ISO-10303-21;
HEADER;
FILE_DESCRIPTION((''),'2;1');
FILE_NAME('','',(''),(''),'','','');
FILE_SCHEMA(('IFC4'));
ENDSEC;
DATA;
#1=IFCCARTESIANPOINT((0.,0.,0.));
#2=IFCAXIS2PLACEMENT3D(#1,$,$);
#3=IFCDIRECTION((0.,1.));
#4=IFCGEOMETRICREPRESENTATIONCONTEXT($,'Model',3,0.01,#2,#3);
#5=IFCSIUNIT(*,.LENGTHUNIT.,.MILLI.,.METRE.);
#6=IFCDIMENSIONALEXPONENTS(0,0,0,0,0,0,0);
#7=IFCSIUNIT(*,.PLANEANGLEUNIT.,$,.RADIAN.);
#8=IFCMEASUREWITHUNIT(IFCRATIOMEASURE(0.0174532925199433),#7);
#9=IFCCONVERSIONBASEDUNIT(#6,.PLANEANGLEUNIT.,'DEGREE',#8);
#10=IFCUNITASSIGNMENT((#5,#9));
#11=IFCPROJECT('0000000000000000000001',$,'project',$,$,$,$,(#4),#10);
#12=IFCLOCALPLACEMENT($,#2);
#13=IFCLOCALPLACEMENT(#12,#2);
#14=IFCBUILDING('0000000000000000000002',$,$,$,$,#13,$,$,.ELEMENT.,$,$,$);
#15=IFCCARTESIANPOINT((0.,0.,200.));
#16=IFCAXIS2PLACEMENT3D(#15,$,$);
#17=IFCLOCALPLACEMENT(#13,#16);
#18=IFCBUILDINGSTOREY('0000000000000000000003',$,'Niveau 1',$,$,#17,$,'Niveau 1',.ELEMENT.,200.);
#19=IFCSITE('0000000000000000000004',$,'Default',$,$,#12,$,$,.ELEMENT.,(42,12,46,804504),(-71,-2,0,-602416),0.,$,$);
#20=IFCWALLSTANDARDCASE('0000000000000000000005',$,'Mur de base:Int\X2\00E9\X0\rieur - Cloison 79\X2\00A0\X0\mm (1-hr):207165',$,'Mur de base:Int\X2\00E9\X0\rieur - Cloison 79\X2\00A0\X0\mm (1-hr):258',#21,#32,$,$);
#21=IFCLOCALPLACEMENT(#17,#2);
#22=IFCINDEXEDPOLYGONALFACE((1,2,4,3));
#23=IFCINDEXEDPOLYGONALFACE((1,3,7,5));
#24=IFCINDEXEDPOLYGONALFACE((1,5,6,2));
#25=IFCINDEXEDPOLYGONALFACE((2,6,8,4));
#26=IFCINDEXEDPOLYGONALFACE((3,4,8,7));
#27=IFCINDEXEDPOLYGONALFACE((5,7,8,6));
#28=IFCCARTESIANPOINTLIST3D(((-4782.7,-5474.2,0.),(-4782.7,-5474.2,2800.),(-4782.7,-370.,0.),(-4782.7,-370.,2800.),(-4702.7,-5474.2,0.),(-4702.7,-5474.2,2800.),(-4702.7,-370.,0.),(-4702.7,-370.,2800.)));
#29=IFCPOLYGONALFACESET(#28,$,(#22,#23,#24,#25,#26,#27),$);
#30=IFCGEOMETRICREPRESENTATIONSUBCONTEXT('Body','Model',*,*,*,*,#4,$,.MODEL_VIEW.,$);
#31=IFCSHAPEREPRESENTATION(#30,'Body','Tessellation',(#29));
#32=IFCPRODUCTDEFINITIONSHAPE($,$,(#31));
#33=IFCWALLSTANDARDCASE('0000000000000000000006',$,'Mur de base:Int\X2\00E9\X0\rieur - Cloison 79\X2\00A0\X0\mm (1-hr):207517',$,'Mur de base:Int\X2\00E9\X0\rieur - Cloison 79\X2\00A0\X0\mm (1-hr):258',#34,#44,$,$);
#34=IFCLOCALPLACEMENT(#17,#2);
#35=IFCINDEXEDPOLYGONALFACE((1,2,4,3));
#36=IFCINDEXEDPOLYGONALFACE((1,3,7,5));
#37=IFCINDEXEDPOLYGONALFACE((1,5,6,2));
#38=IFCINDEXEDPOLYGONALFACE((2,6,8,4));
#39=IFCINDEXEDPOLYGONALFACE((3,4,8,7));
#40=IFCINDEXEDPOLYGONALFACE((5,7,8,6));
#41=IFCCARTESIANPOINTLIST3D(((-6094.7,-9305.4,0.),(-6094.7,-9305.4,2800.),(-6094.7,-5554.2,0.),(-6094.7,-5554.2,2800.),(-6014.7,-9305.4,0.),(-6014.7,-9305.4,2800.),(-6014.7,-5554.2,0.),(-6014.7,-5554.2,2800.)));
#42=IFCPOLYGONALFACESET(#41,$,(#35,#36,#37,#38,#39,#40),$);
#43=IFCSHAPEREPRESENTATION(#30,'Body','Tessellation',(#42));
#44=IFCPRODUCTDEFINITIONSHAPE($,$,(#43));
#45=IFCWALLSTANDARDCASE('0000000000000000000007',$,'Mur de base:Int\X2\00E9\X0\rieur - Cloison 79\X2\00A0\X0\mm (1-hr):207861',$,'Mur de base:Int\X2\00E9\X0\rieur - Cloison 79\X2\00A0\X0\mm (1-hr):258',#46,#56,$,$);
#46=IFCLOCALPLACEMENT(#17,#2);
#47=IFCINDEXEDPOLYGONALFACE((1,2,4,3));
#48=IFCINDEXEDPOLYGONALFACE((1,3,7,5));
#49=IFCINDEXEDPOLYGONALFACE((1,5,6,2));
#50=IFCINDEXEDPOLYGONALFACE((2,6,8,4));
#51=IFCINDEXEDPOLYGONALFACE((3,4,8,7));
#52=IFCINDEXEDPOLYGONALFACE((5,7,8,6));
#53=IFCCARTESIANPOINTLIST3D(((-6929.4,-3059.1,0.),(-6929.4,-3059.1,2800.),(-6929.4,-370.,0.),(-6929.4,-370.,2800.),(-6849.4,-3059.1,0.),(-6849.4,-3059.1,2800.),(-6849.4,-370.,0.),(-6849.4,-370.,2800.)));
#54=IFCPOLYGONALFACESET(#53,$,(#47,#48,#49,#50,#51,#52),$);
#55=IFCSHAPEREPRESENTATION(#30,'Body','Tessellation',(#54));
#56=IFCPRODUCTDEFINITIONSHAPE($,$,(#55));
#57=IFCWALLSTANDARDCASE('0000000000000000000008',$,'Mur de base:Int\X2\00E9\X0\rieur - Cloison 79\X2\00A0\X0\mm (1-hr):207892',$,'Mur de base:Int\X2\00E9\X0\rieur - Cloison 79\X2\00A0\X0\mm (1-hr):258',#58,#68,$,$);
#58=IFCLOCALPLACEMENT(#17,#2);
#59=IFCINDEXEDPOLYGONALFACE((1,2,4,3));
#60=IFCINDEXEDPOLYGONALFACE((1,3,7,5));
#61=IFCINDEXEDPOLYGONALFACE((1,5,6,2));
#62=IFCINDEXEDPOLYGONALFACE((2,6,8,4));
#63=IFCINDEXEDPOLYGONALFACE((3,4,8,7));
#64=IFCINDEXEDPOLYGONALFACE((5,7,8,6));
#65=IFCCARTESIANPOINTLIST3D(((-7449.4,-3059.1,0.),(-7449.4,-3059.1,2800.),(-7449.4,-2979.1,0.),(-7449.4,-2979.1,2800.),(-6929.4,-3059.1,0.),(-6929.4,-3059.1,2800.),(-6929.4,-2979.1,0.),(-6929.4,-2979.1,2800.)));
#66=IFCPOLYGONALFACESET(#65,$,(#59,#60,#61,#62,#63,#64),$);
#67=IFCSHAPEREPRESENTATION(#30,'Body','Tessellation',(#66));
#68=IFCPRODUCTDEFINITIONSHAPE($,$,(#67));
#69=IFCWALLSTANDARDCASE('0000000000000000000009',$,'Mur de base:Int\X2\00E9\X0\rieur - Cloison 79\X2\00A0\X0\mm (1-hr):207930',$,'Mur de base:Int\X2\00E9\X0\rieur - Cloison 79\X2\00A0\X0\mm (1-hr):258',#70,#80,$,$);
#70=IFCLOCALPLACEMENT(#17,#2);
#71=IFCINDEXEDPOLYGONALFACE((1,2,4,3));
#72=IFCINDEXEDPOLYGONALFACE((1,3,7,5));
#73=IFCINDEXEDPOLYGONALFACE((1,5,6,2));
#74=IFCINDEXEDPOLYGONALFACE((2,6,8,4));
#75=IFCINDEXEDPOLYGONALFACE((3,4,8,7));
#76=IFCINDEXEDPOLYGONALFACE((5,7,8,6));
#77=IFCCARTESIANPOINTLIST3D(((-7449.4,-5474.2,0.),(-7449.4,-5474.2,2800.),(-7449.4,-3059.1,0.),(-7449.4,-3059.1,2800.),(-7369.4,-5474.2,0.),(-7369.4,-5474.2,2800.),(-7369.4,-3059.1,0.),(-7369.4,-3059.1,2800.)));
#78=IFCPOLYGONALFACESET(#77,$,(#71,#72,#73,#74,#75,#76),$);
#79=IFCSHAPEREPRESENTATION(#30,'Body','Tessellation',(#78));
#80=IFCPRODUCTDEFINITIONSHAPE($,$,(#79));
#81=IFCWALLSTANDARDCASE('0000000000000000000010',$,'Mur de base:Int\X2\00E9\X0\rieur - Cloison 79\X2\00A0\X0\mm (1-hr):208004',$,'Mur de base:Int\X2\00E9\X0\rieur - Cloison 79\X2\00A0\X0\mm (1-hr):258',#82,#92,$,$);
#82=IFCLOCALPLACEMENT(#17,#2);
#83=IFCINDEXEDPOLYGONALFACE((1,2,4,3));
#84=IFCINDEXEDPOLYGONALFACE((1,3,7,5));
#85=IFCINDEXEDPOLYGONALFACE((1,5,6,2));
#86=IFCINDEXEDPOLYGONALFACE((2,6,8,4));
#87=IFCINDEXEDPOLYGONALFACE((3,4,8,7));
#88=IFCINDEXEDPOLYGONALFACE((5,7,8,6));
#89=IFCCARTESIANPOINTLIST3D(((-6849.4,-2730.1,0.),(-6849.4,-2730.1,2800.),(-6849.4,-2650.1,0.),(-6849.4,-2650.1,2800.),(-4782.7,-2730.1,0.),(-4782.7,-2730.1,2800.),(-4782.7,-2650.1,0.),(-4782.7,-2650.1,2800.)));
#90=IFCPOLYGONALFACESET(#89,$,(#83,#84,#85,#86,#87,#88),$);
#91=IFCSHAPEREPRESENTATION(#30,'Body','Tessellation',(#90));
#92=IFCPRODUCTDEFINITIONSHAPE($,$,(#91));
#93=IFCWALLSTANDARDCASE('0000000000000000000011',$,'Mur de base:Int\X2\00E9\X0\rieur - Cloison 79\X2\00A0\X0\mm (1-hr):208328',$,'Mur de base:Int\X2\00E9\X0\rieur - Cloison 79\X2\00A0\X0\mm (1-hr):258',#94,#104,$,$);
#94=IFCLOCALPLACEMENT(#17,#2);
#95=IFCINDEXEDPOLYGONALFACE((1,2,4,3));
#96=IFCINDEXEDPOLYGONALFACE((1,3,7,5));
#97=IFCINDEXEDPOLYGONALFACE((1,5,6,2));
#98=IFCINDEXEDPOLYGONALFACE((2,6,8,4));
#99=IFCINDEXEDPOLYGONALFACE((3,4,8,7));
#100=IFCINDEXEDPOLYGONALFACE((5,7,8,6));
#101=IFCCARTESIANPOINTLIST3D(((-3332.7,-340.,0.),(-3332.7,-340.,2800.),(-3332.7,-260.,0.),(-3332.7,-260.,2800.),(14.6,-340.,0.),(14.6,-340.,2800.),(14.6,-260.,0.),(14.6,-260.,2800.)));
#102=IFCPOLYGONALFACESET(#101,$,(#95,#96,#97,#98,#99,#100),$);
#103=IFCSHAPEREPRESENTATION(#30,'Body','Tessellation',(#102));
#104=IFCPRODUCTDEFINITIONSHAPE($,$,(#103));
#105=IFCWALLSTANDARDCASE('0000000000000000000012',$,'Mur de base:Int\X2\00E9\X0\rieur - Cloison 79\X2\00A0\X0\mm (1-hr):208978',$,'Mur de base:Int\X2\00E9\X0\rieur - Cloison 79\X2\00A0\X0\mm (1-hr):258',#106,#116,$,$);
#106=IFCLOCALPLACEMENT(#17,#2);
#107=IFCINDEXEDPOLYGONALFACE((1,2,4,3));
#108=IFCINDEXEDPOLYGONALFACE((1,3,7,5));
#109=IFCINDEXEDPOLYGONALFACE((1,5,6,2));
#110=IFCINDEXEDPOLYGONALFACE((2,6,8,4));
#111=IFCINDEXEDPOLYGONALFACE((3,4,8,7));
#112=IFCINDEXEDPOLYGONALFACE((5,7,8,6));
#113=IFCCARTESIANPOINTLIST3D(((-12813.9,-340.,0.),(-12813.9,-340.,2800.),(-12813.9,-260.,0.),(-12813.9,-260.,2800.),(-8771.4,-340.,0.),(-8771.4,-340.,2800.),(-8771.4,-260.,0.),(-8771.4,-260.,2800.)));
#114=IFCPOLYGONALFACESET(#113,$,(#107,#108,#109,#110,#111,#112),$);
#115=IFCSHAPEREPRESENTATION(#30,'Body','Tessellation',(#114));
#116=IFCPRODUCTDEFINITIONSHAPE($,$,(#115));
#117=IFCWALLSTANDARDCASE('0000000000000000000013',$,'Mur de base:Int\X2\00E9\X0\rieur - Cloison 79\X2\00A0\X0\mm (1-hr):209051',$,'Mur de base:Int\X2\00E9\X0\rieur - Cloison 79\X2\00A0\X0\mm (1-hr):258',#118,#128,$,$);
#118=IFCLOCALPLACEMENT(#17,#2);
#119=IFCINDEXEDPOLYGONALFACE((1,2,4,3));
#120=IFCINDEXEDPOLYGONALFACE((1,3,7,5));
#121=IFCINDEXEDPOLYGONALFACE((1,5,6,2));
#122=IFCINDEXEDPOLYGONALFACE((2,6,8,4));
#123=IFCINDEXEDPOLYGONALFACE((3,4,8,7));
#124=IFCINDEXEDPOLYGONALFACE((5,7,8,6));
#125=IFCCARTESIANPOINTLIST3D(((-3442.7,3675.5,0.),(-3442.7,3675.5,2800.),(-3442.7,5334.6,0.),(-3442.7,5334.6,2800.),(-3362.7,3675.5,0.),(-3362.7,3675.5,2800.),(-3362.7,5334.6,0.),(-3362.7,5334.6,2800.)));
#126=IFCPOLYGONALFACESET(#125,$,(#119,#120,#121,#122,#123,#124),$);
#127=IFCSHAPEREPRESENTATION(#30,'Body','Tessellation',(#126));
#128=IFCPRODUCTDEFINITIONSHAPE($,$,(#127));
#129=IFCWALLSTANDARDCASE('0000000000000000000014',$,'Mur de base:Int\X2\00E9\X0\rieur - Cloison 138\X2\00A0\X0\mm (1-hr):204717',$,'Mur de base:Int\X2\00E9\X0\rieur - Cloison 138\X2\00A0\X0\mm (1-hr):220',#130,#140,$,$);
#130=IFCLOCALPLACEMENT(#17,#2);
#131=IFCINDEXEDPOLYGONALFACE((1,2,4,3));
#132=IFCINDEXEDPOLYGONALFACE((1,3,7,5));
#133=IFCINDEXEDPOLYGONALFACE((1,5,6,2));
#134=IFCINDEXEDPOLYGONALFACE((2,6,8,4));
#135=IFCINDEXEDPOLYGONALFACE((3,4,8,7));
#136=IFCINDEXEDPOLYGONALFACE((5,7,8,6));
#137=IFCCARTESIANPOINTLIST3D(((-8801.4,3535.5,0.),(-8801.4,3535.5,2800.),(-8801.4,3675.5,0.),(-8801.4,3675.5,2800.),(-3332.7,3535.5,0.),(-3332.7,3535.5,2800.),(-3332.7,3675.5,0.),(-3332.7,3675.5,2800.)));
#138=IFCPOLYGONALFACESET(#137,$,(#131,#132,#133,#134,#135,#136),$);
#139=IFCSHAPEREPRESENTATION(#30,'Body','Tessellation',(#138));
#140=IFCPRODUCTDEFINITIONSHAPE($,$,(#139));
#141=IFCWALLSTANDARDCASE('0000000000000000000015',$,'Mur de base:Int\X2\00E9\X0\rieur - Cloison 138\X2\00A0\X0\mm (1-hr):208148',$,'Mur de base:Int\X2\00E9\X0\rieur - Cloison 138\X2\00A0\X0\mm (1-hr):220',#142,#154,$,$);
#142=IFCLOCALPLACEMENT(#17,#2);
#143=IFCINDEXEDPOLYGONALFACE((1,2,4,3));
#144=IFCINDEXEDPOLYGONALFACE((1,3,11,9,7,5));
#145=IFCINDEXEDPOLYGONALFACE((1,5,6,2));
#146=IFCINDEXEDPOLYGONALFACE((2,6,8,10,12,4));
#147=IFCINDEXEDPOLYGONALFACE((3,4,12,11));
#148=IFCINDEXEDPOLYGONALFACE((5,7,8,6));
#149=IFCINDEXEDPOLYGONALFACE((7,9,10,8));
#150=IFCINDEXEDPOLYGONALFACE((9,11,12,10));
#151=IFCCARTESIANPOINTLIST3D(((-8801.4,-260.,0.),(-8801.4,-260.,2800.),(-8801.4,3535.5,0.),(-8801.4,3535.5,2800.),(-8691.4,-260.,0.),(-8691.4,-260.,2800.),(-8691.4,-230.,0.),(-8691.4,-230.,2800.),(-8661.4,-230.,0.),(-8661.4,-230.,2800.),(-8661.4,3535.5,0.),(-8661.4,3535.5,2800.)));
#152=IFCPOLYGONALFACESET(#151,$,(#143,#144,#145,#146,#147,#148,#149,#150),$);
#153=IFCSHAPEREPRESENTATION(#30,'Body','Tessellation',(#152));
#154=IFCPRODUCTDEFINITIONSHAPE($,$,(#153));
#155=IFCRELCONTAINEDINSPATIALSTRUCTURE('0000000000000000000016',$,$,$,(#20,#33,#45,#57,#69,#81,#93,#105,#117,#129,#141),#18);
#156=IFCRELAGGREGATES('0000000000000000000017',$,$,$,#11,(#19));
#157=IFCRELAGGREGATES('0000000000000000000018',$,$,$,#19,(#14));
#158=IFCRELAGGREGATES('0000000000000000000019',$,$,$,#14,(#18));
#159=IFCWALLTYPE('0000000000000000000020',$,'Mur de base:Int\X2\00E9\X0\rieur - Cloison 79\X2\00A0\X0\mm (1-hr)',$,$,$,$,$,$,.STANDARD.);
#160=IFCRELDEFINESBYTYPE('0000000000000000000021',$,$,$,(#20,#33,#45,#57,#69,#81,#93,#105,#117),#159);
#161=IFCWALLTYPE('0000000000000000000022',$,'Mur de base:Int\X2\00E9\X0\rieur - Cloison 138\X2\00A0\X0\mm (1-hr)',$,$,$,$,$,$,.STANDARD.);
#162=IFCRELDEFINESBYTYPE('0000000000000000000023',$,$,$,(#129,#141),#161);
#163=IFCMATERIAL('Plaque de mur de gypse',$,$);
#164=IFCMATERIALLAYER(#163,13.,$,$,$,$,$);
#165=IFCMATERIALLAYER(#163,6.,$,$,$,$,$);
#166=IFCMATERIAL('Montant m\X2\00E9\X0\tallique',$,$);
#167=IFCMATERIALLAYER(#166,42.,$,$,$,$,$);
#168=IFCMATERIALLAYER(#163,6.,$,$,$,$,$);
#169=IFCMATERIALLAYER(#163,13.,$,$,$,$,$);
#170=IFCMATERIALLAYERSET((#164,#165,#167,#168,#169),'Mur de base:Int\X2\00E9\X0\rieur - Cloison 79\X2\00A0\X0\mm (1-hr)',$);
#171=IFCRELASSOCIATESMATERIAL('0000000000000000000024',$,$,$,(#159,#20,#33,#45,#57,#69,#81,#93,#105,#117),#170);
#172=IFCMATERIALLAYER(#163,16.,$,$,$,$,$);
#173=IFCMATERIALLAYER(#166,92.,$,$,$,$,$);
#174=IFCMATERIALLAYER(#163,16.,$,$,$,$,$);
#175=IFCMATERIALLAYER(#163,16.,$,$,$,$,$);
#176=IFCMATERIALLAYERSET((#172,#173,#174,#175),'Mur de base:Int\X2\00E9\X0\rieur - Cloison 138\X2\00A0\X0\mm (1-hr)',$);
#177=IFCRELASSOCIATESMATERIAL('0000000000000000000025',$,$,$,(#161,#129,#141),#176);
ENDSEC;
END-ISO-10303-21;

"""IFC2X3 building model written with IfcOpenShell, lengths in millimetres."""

from ifc_helpers import new_model, entity, si_unit, converted_unit, direction, frame, frame_2d, origin, place, context, subcontext, project, spatial, polyline, rectangle, outline, extrude, clip, bounded_halfspace, material, layer, layer_set, layer_usage, type_object, element, save


model = new_model("IFC2X3")

# Units and contexts
model_context = context("Model", 3, precision=0.01, world=origin(), true_north=direction((0.0, 1.0)))
body_context = subcontext(model_context, "Body", "Model", "MODEL_VIEW")
ifc_project = project(units=[si_unit("LENGTHUNIT", "METRE", prefix="MILLI"), converted_unit("PLANEANGLEUNIT", "DEGREE", entity("IfcRatioMeasure", 0.0174532925199433), si_unit("PLANEANGLEUNIT", "RADIAN"), dimensions=[0, 0, 0, 0, 0, 0, 0])], contexts=[model_context])

# Site, building, storey
site_placement = place(None, origin())
site = spatial("IfcSite", under=ifc_project, at=site_placement, Name="Default", CompositionType="ELEMENT", RefLatitude=(42, 12, 46, 804504), RefLongitude=(-71, -2, 0, -602416), RefElevation=0.0)
building_placement = place(site_placement, origin())
building = spatial("IfcBuilding", under=site, at=building_placement, CompositionType="ELEMENT")
storey_placement = place(building_placement, frame((0.0, 0.0, 200.0)))
storey = spatial("IfcBuildingStorey", under=building, at=storey_placement, Name="Niveau 1", LongName="Niveau 1", CompositionType="ELEMENT", Elevation=200.0)

# Walls
ifc_material_1 = material(Name="Plaque de mur de gypse")
ifc_layer_1 = layer(ifc_material_1, 13.0)
ifc_layer_2 = layer(ifc_material_1, 6.0)
ifc_material_2 = material(Name="Montant métallique")
ifc_layer_3 = layer(ifc_material_2, 42.0)
ifc_layer_4 = layer(ifc_material_1, 6.0)
ifc_layer_5 = layer(ifc_material_1, 13.0)
ifc_layer_set_1 = layer_set([ifc_layer_1, ifc_layer_2, ifc_layer_3, ifc_layer_4, ifc_layer_5], Name="Mur de base:Intérieur - Cloison 79 mm (1-hr)")
wall_type_1 = type_object("IfcWallType", Name="Mur de base:Intérieur - Cloison 79 mm (1-hr)", PredefinedType="STANDARD", material=ifc_layer_set_1)
ifc_layer_usage_1 = layer_usage(ifc_layer_set_1, "AXIS2", "NEGATIVE", 40.0)
wall_1_placement = place(storey_placement, frame((-4742.7, -370.0, 0.0), z_axis=(0.0, 0.0, 1.0), x_axis=(0.0, -1.0, 0.0)))
element("IfcWallStandardCase", 1, at=wall_1_placement, inside=storey, type_object=wall_type_1, material=ifc_layer_usage_1, Name="Mur de base:Intérieur - Cloison 79 mm (1-hr):207165", ObjectType="Mur de base:Intérieur - Cloison 79 mm (1-hr):258", context=body_context, shape_type="Clipping", body=[
    clip(extrude(rectangle(XDim=5104.2, YDim=80.0, at=frame_2d((2552.1, 0.0), x_axis=(-1.0, 0.0))), origin(), (0.0, 0.0, 1.0), 2800.0), bounded_halfspace(frame((0.0, -40.0, 2800.0), z_axis=(0.0, 0.0, -1.0), x_axis=(-1.0, 0.0, 0.0)), True, frame((0.0, -40.0, 2800.0)), polyline([(0.0, 0.0), (2280.1, 0.0), (2360.1, 0.0), (5104.2, 0.0), (5104.2, 80.0), (0.0, 80.0), (0.0, 0.0)]))),
])
ifc_layer_usage_2 = layer_usage(ifc_layer_set_1, "AXIS2", "NEGATIVE", 40.0)
wall_2_placement = place(storey_placement, frame((-6054.7, -5554.2, 0.0), z_axis=(0.0, 0.0, 1.0), x_axis=(0.0, -1.0, 0.0)))
element("IfcWallStandardCase", 2, at=wall_2_placement, inside=storey, type_object=wall_type_1, material=ifc_layer_usage_2, Name="Mur de base:Intérieur - Cloison 79 mm (1-hr):207517", ObjectType="Mur de base:Intérieur - Cloison 79 mm (1-hr):258", context=body_context, shape_type="Clipping", body=[
    clip(extrude(rectangle(XDim=3751.2, YDim=80.0, at=frame_2d((1875.6, 0.0), x_axis=(-1.0, 0.0))), origin(), (0.0, 0.0, 1.0), 2800.0), bounded_halfspace(frame((0.0, -40.0, 2800.0), z_axis=(0.0, 0.0, -1.0), x_axis=(-1.0, 0.0, 0.0)), True, frame((0.0, -40.0, 2800.0)), polyline([(0.0, 0.0), (3751.2, 0.0), (3751.2, 80.0), (0.0, 80.0), (0.0, 0.0)]))),
])
ifc_layer_usage_3 = layer_usage(ifc_layer_set_1, "AXIS2", "NEGATIVE", 40.0)
wall_3_placement = place(storey_placement, frame((-6889.4, -370.0, 0.0), z_axis=(0.0, 0.0, 1.0), x_axis=(0.0, -1.0, 0.0)))
element("IfcWallStandardCase", 3, at=wall_3_placement, inside=storey, type_object=wall_type_1, material=ifc_layer_usage_3, Name="Mur de base:Intérieur - Cloison 79 mm (1-hr):207861", ObjectType="Mur de base:Intérieur - Cloison 79 mm (1-hr):258", context=body_context, shape_type="Clipping", body=[
    clip(extrude(rectangle(XDim=2689.1, YDim=80.0, at=frame_2d((1344.6, 0.0), x_axis=(-1.0, 0.0))), origin(), (0.0, 0.0, 1.0), 2800.0), bounded_halfspace(frame((0.0, -40.0, 2800.0), z_axis=(0.0, 0.0, -1.0), x_axis=(-1.0, 0.0, 0.0)), True, frame((0.0, -40.0, 2800.0)), polyline([(0.0, 0.0), (2609.1, 0.0), (2689.1, 0.0), (2689.1, 80.0), (2360.1, 80.0), (2280.1, 80.0), (0.0, 80.0), (0.0, 0.0)]))),
])
ifc_layer_usage_4 = layer_usage(ifc_layer_set_1, "AXIS2", "NEGATIVE", 40.0)
wall_4_placement = place(storey_placement, frame((-6929.4, -3019.1, 0.0), z_axis=(0.0, 0.0, 1.0), x_axis=(-1.0, 0.0, 0.0)))
element("IfcWallStandardCase", 4, at=wall_4_placement, inside=storey, type_object=wall_type_1, material=ifc_layer_usage_4, Name="Mur de base:Intérieur - Cloison 79 mm (1-hr):207892", ObjectType="Mur de base:Intérieur - Cloison 79 mm (1-hr):258", context=body_context, shape_type="Clipping", body=[
    clip(extrude(rectangle(XDim=520.0, YDim=80.0, at=frame_2d((260.0, 0.0), x_axis=(-1.0, 0.0))), origin(), (0.0, 0.0, 1.0), 2800.0), bounded_halfspace(frame((0.0, -40.0, 2800.0), z_axis=(0.0, 0.0, -1.0), x_axis=(0.0, -1.0, 0.0)), True, frame((0.0, -40.0, 2800.0)), polyline([(0.0, 0.0), (520.0, 0.0), (520.0, 80.0), (440.0, 80.0), (0.0, 80.0), (0.0, 0.0)]))),
])
ifc_layer_usage_5 = layer_usage(ifc_layer_set_1, "AXIS2", "NEGATIVE", 40.0)
wall_5_placement = place(storey_placement, frame((-7409.4, -3059.1, 0.0), z_axis=(0.0, 0.0, 1.0), x_axis=(0.0, -1.0, 0.0)))
element("IfcWallStandardCase", 5, at=wall_5_placement, inside=storey, type_object=wall_type_1, material=ifc_layer_usage_5, Name="Mur de base:Intérieur - Cloison 79 mm (1-hr):207930", ObjectType="Mur de base:Intérieur - Cloison 79 mm (1-hr):258", context=body_context, shape_type="Clipping", body=[
    clip(extrude(rectangle(XDim=2415.1, YDim=80.0, at=frame_2d((1207.5, 0.0), x_axis=(-1.0, 0.0))), origin(), (0.0, 0.0, 1.0), 2800.0), bounded_halfspace(frame((0.0, -40.0, 2800.0), z_axis=(0.0, 0.0, -1.0), x_axis=(-1.0, 0.0, 0.0)), True, frame((0.0, -40.0, 2800.0)), polyline([(0.0, 0.0), (2415.1, 0.0), (2415.1, 80.0), (0.0, 80.0), (0.0, 0.0)]))),
])
ifc_layer_usage_6 = layer_usage(ifc_layer_set_1, "AXIS2", "NEGATIVE", 40.0)
wall_6_placement = place(storey_placement, frame((-6849.4, -2690.1, 0.0)))
element("IfcWallStandardCase", 6, at=wall_6_placement, inside=storey, type_object=wall_type_1, material=ifc_layer_usage_6, Name="Mur de base:Intérieur - Cloison 79 mm (1-hr):208004", ObjectType="Mur de base:Intérieur - Cloison 79 mm (1-hr):258", context=body_context, shape_type="Clipping", body=[
    clip(extrude(rectangle(XDim=2066.8, YDim=80.0, at=frame_2d((1033.4, 0.0), x_axis=(-1.0, 0.0))), origin(), (0.0, 0.0, 1.0), 2800.0), bounded_halfspace(frame((0.0, -40.0, 2800.0), z_axis=(0.0, 0.0, -1.0), x_axis=(0.0, 1.0, 0.0)), True, frame((0.0, -40.0, 2800.0)), polyline([(0.0, 0.0), (2066.8, 0.0), (2066.8, 80.0), (0.0, 80.0), (0.0, 0.0)]))),
])
ifc_layer_usage_7 = layer_usage(ifc_layer_set_1, "AXIS2", "NEGATIVE", 40.0)
wall_7_placement = place(storey_placement, frame((-3332.7, -300.0, 0.0)))
element("IfcWallStandardCase", 7, at=wall_7_placement, inside=storey, type_object=wall_type_1, material=ifc_layer_usage_7, Name="Mur de base:Intérieur - Cloison 79 mm (1-hr):208328", ObjectType="Mur de base:Intérieur - Cloison 79 mm (1-hr):258", context=body_context, shape_type="Clipping", body=[
    clip(extrude(rectangle(XDim=3347.3, YDim=80.0, at=frame_2d((1673.6, 0.0), x_axis=(-1.0, 0.0))), origin(), (0.0, 0.0, 1.0), 2800.0), bounded_halfspace(frame((0.0, -40.0, 2800.0), z_axis=(0.0, 0.0, -1.0), x_axis=(0.0, 1.0, 0.0)), True, frame((0.0, -40.0, 2800.0)), polyline([(0.0, 0.0), (830.0, 0.0), (910.0, 0.0), (3347.3, 0.0), (3347.3, 80.0), (0.0, 80.0), (0.0, 0.0)]))),
])
ifc_layer_usage_8 = layer_usage(ifc_layer_set_1, "AXIS2", "NEGATIVE", 40.0)
wall_8_placement = place(storey_placement, frame((-8771.4, -300.0, 0.0), z_axis=(0.0, 0.0, 1.0), x_axis=(-1.0, 0.0, 0.0)))
element("IfcWallStandardCase", 8, at=wall_8_placement, inside=storey, type_object=wall_type_1, material=ifc_layer_usage_8, Name="Mur de base:Intérieur - Cloison 79 mm (1-hr):208978", ObjectType="Mur de base:Intérieur - Cloison 79 mm (1-hr):258", context=body_context, shape_type="Clipping", body=[
    clip(extrude(rectangle(XDim=4042.6, YDim=80.0, at=frame_2d((2021.3, 0.0), x_axis=(-1.0, 0.0))), origin(), (0.0, 0.0, 1.0), 2800.0), bounded_halfspace(frame((0.0, -40.0, 2800.0), z_axis=(0.0, 0.0, -1.0), x_axis=(0.0, -1.0, 0.0)), True, frame((0.0, -40.0, 2800.0)), polyline([(0.0, 0.0), (30.0, 0.0), (4042.6, 0.0), (4042.6, 80.0), (1157.3, 80.0), (1077.3, 80.0), (0.0, 80.0), (0.0, 0.0)]))),
])
ifc_layer_usage_9 = layer_usage(ifc_layer_set_1, "AXIS2", "NEGATIVE", 40.0)
wall_9_placement = place(storey_placement, frame((-3402.7, 3675.5, 0.0), z_axis=(0.0, 0.0, 1.0), x_axis=(0.0, 1.0, 0.0)))
element("IfcWallStandardCase", 9, at=wall_9_placement, inside=storey, type_object=wall_type_1, material=ifc_layer_usage_9, Name="Mur de base:Intérieur - Cloison 79 mm (1-hr):209051", ObjectType="Mur de base:Intérieur - Cloison 79 mm (1-hr):258", context=body_context, shape_type="Clipping", body=[
    clip(extrude(rectangle(XDim=1659.0, YDim=80.0, at=frame_2d((829.5, 0.0), x_axis=(-1.0, 0.0))), origin(), (0.0, 0.0, 1.0), 2800.0), bounded_halfspace(frame((0.0, -40.0, 2800.0), z_axis=(0.0, 0.0, -1.0), x_axis=(1.0, 0.0, 0.0)), True, frame((0.0, -40.0, 2800.0)), polyline([(0.0, 0.0), (1659.0, 0.0), (1659.0, 80.0), (0.0, 80.0), (0.0, 0.0)]))),
])
ifc_layer_6 = layer(ifc_material_1, 16.0)
ifc_layer_7 = layer(ifc_material_2, 92.0)
ifc_layer_8 = layer(ifc_material_1, 16.0)
ifc_layer_9 = layer(ifc_material_1, 16.0)
ifc_layer_set_2 = layer_set([ifc_layer_6, ifc_layer_7, ifc_layer_8, ifc_layer_9], Name="Mur de base:Intérieur - Cloison 138 mm (1-hr)")
ifc_layer_usage_10 = layer_usage(ifc_layer_set_2, "AXIS2", "NEGATIVE", 70.0)
wall_type_2 = type_object("IfcWallType", Name="Mur de base:Intérieur - Cloison 138 mm (1-hr)", PredefinedType="STANDARD", material=ifc_layer_set_2)
wall_10_placement = place(storey_placement, frame((-8801.4, 3605.5, 0.0)))
element("IfcWallStandardCase", 10, at=wall_10_placement, inside=storey, type_object=wall_type_2, material=ifc_layer_usage_10, Name="Mur de base:Intérieur - Cloison 138 mm (1-hr):204717", ObjectType="Mur de base:Intérieur - Cloison 138 mm (1-hr):220", context=body_context, shape_type="Clipping", body=[
    clip(extrude(rectangle(XDim=5468.7, YDim=140.0, at=frame_2d((2734.4, 0.0), x_axis=(-1.0, 0.0))), origin(), (0.0, 0.0, 1.0), 2800.0), bounded_halfspace(frame((0.0, -70.0, 2800.0), z_axis=(0.0, 0.0, -1.0), x_axis=(0.0, 1.0, 0.0)), True, frame((0.0, -70.0, 2800.0)), polyline([(0.0, 0.0), (140.0, 0.0), (5328.7, 0.0), (5468.7, 0.0), (5468.7, 140.0), (5438.7, 140.0), (5358.7, 140.0), (3306.0, 140.0), (3226.0, 140.0), (0.0, 140.0), (0.0, 0.0)]))),
])
ifc_layer_usage_11 = layer_usage(ifc_layer_set_2, "AXIS2", "NEGATIVE", 70.0)
wall_11_placement = place(storey_placement, frame((-8731.4, -260.0, 0.0), z_axis=(0.0, 0.0, 1.0), x_axis=(0.0, 1.0, 0.0)))
element("IfcWallStandardCase", 11, at=wall_11_placement, inside=storey, type_object=wall_type_2, material=ifc_layer_usage_11, Name="Mur de base:Intérieur - Cloison 138 mm (1-hr):208148", ObjectType="Mur de base:Intérieur - Cloison 138 mm (1-hr):220", context=body_context, shape_type="Clipping", body=[
    clip(extrude(outline(polyline([(3795.5, -70.0), (3795.5, 70.0), (2405.5, 70.0), (2325.5, 70.0), (0.0, 70.0), (0.0, 40.0), (0.0, -40.0), (30.0, -40.0), (30.0, -70.0), (3795.5, -70.0)])), origin(), (0.0, 0.0, 1.0), 2800.0), bounded_halfspace(frame((30.0, -70.0, 2800.0), z_axis=(0.0, 0.0, -1.0), x_axis=(1.0, 0.0, 0.0)), True, frame((30.0, -70.0, 2800.0)), polyline([(0.0, 0.0), (3765.5, 0.0), (3765.5, 140.0), (2375.5, 140.0), (2295.5, 140.0), (-30.0, 140.0), (-30.0, 110.0), (-30.0, 30.0), (0.0, 30.0), (0.0, 0.0)]))),
])

save(model, "model.ifc")
